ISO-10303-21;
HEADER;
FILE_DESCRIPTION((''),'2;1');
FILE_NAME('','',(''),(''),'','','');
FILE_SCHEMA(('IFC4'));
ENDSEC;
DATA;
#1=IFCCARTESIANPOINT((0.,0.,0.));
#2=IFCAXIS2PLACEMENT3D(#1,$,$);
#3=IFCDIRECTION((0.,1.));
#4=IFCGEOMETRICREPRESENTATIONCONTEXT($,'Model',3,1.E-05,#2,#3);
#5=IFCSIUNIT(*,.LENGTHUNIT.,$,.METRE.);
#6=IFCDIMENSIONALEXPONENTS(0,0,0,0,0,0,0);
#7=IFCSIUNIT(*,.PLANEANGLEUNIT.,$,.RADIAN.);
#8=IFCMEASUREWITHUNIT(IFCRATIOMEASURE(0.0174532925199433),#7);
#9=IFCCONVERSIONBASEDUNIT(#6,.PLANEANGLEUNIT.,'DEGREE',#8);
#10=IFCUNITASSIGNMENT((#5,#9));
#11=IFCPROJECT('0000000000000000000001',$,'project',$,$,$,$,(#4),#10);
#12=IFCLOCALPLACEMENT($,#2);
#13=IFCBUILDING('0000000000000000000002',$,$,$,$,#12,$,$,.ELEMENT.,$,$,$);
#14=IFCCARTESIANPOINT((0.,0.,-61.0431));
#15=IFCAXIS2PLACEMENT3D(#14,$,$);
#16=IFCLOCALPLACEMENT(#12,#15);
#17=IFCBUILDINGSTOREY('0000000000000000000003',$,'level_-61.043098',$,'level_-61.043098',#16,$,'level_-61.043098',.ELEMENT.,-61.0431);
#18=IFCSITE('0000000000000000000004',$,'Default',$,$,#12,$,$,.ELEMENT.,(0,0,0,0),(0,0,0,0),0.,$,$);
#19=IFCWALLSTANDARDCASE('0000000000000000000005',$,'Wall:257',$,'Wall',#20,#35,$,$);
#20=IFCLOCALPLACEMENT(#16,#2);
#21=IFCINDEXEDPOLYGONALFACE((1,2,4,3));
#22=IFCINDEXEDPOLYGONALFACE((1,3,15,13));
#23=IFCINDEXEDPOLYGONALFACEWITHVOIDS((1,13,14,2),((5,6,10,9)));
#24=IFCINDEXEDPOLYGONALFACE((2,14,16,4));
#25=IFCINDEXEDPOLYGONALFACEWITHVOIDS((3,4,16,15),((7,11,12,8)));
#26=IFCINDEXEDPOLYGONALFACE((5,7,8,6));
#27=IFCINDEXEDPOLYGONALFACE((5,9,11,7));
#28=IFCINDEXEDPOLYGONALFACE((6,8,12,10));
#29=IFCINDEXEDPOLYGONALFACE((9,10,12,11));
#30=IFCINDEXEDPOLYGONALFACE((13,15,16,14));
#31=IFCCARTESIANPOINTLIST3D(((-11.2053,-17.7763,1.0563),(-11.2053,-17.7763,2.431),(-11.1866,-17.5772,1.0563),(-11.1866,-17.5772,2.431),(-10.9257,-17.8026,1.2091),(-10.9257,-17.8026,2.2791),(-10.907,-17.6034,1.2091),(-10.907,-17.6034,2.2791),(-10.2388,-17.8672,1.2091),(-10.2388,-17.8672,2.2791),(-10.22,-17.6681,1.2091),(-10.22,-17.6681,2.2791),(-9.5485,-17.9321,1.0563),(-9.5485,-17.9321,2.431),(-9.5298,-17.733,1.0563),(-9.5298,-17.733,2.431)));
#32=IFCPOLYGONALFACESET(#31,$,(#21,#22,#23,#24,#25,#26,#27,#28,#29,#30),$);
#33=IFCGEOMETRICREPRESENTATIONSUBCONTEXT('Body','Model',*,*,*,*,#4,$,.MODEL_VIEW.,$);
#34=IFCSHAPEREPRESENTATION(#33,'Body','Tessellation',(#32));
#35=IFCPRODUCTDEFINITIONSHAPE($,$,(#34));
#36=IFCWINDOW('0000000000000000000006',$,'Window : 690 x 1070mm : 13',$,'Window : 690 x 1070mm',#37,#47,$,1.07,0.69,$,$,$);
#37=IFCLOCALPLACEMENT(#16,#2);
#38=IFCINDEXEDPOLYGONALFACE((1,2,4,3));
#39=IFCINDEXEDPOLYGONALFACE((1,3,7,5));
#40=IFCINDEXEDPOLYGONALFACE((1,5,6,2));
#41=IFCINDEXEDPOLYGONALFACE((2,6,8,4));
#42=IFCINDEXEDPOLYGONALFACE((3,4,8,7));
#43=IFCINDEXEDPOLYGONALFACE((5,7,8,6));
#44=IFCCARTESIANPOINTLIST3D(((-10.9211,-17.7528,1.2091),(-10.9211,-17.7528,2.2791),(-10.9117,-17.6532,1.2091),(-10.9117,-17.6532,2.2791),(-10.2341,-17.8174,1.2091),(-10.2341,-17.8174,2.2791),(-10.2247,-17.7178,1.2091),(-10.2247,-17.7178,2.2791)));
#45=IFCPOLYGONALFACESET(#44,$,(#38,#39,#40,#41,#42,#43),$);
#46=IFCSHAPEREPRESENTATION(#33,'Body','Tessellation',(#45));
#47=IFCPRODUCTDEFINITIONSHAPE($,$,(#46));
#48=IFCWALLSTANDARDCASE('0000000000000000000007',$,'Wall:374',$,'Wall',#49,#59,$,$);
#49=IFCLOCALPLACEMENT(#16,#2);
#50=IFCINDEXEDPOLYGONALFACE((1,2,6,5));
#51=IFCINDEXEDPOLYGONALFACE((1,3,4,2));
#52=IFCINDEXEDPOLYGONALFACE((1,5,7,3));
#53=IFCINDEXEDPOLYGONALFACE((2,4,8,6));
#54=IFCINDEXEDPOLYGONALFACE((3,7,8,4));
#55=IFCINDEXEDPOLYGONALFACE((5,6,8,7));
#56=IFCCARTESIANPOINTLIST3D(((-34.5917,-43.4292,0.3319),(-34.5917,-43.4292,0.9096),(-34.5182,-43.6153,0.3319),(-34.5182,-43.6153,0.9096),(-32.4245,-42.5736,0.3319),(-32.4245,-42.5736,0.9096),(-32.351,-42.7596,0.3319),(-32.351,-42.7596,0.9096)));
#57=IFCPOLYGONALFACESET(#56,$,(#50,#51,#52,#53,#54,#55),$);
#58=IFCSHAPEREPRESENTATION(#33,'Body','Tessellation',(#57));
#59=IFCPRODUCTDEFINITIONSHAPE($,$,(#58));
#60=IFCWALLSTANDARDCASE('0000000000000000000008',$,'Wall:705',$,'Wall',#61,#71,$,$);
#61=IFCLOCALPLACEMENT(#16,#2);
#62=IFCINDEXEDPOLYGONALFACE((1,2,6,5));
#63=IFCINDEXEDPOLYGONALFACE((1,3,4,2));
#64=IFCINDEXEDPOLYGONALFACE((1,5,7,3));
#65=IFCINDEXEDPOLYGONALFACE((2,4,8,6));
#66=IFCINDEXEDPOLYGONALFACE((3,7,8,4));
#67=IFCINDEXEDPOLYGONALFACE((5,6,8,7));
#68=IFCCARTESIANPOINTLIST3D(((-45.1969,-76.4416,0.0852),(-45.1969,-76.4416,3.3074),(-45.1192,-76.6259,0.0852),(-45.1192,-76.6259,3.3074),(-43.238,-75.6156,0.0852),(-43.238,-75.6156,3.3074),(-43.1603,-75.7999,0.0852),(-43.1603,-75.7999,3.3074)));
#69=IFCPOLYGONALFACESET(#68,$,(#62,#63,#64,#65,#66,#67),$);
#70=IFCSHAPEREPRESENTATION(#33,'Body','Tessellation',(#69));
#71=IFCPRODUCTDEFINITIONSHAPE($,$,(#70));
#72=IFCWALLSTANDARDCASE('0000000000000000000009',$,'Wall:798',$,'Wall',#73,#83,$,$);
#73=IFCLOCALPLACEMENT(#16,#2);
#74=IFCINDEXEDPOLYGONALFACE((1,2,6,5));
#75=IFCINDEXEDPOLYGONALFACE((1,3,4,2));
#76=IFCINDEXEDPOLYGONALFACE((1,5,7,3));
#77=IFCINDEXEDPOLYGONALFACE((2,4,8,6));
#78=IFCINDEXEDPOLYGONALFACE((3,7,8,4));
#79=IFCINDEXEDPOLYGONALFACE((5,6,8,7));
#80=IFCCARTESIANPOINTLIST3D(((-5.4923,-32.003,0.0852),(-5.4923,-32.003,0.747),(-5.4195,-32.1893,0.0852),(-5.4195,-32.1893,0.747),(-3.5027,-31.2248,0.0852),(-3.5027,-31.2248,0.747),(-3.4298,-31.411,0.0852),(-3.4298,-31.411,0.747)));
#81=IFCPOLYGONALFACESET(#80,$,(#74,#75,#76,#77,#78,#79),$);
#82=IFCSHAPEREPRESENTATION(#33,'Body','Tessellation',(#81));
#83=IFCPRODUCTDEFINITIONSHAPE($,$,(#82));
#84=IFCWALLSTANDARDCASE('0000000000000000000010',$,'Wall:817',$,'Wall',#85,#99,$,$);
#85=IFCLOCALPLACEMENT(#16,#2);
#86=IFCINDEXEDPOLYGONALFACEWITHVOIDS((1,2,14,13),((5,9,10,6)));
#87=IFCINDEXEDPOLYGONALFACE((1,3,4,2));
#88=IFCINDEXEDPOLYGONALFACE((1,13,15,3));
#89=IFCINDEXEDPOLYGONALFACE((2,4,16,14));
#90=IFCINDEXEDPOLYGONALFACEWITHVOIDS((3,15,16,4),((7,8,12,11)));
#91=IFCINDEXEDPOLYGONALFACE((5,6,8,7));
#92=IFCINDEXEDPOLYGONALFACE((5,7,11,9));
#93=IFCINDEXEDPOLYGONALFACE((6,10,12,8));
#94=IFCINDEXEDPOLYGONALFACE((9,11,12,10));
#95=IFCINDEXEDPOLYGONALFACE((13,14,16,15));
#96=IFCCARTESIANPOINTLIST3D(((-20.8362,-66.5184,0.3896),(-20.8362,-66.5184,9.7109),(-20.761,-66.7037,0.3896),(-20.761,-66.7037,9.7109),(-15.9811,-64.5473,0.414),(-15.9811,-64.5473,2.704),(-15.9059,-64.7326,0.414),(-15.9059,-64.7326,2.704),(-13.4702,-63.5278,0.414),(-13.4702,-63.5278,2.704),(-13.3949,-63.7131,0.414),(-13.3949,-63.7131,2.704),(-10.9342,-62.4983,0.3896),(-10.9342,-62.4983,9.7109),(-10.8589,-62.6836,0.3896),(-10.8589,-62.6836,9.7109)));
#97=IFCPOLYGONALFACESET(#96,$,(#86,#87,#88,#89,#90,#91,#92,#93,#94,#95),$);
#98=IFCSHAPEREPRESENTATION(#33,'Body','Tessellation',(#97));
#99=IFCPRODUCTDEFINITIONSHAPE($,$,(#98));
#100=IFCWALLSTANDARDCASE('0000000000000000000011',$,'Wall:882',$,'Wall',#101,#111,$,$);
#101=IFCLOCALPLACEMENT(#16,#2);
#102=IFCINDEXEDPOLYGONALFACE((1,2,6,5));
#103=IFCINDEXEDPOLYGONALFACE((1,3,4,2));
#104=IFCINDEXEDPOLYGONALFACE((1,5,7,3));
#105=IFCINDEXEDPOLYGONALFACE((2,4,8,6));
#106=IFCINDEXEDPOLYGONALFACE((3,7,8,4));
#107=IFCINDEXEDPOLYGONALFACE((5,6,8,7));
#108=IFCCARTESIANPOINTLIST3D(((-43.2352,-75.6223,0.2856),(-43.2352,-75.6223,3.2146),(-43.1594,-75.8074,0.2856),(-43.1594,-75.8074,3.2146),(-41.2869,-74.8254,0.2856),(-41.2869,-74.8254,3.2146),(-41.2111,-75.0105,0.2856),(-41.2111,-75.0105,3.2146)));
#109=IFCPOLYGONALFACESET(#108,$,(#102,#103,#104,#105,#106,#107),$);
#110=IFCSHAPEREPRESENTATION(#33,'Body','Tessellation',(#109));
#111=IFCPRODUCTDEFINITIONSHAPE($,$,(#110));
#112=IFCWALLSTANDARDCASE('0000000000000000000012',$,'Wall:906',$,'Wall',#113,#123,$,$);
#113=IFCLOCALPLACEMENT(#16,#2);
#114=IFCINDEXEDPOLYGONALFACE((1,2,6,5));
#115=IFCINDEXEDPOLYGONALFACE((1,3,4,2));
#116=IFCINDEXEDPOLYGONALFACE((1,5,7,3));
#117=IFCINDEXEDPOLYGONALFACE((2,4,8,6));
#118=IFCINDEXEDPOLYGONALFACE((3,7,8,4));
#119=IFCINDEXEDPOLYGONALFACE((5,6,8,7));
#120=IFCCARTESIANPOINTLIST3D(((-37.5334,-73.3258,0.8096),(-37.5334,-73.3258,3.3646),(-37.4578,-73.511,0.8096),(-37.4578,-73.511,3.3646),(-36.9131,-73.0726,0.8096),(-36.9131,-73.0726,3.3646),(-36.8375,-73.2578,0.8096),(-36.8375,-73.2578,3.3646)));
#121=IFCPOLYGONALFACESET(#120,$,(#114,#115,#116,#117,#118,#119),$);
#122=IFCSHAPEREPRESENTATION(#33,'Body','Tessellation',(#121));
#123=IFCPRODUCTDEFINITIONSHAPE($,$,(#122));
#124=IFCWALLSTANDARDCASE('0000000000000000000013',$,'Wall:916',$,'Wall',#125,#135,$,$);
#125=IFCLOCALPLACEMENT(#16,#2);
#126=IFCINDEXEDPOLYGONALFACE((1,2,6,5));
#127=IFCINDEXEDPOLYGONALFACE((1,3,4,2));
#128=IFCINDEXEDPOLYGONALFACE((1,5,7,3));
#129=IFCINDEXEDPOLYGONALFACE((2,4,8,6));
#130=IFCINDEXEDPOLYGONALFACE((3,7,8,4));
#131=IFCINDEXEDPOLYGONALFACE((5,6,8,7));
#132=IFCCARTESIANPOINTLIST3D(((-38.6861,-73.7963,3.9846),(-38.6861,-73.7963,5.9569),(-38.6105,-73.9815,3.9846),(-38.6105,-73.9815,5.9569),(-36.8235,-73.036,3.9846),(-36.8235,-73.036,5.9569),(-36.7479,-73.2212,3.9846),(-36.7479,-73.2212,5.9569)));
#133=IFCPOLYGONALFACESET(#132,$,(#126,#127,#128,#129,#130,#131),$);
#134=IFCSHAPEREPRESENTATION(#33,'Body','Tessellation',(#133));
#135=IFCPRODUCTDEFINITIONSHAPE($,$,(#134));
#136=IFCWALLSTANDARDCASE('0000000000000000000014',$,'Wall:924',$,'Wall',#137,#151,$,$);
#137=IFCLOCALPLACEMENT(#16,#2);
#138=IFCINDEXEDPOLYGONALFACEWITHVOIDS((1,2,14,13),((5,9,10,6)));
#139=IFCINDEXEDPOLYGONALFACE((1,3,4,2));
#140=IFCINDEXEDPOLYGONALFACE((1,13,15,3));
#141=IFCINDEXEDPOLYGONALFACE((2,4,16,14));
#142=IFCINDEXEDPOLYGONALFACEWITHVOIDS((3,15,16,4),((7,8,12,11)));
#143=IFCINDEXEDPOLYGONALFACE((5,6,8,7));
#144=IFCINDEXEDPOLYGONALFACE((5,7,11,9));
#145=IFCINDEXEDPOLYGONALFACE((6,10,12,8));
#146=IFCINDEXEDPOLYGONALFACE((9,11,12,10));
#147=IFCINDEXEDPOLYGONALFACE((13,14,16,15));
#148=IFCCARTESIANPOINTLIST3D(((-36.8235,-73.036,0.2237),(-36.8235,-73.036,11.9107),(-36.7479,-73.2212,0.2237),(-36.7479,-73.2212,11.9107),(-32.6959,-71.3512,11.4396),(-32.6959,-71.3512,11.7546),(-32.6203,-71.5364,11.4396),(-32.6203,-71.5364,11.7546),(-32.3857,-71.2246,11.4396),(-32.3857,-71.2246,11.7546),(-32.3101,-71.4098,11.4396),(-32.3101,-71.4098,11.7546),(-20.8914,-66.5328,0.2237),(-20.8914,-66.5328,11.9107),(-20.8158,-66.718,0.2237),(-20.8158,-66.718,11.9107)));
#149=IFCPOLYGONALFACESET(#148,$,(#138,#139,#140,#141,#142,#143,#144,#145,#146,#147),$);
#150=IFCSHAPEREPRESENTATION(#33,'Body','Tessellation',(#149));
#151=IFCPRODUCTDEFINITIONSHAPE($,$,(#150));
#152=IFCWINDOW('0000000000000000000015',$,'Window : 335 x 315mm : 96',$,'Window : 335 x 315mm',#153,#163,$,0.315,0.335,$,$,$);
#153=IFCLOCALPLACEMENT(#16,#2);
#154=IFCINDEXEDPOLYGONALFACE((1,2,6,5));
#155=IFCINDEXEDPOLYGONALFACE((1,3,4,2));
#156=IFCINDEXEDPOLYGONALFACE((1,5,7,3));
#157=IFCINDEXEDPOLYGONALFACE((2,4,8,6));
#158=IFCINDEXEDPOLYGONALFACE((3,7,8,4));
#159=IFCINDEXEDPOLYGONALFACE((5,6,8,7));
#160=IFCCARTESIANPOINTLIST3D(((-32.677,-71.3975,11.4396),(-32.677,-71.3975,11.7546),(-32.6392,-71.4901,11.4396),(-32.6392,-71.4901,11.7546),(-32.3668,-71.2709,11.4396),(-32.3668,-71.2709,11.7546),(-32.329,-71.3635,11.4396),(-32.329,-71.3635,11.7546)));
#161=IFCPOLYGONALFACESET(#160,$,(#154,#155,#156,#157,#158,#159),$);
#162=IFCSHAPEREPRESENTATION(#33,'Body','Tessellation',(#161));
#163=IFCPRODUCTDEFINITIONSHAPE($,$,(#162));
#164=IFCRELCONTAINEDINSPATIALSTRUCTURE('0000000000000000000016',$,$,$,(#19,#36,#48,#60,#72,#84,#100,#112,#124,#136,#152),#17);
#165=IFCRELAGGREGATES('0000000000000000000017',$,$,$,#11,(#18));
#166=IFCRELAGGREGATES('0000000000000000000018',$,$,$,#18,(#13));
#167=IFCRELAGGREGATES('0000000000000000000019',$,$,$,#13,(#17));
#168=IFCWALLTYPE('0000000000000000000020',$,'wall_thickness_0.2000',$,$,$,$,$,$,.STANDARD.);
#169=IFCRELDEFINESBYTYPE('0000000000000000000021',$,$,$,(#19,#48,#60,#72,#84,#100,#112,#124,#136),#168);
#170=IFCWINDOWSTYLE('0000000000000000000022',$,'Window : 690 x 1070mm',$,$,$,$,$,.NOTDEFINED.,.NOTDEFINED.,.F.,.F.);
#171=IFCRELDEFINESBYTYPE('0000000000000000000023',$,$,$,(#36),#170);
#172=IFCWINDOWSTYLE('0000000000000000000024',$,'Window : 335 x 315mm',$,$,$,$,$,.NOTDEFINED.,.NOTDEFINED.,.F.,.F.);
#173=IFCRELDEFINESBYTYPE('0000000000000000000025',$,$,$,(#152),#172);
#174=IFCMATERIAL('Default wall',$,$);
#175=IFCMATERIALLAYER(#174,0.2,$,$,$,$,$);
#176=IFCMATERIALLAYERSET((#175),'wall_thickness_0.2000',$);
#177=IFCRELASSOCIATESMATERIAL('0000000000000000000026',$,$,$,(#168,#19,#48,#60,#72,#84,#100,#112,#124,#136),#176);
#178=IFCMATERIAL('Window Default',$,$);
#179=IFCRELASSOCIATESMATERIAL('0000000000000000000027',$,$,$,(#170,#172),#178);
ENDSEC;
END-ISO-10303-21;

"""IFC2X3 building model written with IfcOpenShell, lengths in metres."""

from ifc_helpers import new_model, entity, si_unit, converted_unit, direction, frame, frame_2d, origin, origin_2d_with_axis, place, context, subcontext, project, spatial, polyline, rectangle, outline, extrude, source, transform, mapped, material, layer, layer_set, layer_usage, type_object, type_shapes, element, fill, save


model = new_model("IFC2X3")

# Units and contexts
model_context = context("Model", 3, precision=1e-05, world=origin(), true_north=direction((0.0, 1.0)))
body_context = subcontext(model_context, "Body", "Model", "MODEL_VIEW")
ifc_project = project(units=[si_unit("LENGTHUNIT", "METRE"), converted_unit("PLANEANGLEUNIT", "DEGREE", entity("IfcRatioMeasure", 0.0174532925199433), si_unit("PLANEANGLEUNIT", "RADIAN"), dimensions=[0, 0, 0, 0, 0, 0, 0])], contexts=[model_context])

# Site, building, storey
placement_1 = place(None, origin())
site = spatial("IfcSite", under=ifc_project, at=placement_1, Name="Default", CompositionType="ELEMENT", RefLatitude=(0, 0, 0, 0), RefLongitude=(0, 0, 0, 0), RefElevation=0.0)
building = spatial("IfcBuilding", under=site, at=placement_1, CompositionType="ELEMENT")
storey_placement = place(placement_1, frame((0.0, 0.0, -61.0431)))
storey = spatial("IfcBuildingStorey", under=building, at=storey_placement, Name="level_-61.043098", ObjectType="level_-61.043098", LongName="level_-61.043098", CompositionType="ELEMENT", Elevation=-61.0431)

# Wall, opening, window
ifc_material_1 = material(Name="Default wall")
ifc_layer = layer(ifc_material_1, 0.2)
ifc_layer_set = layer_set([ifc_layer], Name="wall_thickness_0.2000")
ifc_layer_usage = layer_usage(ifc_layer_set, "AXIS2", "POSITIVE", -0.1)
wall_type = type_object("IfcWallType", Name="wall_thickness_0.2000", PredefinedType="STANDARD", material=ifc_layer_set)
placement_2 = place(placement_1, frame((0.0, 0.0, -59.9868)))
wall_1_placement = place(placement_2, frame((-9.5391, -17.8325, 0.0), z_axis=(0.0, 0.0, 1.0), x_axis=(-0.995607, 0.09363, 0.0)))
wall_1 = element("IfcWallStandardCase", 1, at=wall_1_placement, inside=storey, type_object=wall_type, material=ifc_layer_usage, Name="Wall:257", ObjectType="Wall", context=body_context, shape_type="SweptSolid", body=[
    extrude(outline(polyline([(1.6642, -0.1), (1.6642, 0.1), (0.0, 0.1), (0.0, -0.1), (1.6642, -0.1)])), origin(), (0.0, 0.0, 1.0), 1.3747),
])
opening_1_placement = place(wall_1_placement, frame((0.6933, -0.1, 0.1528)))
opening_1 = element("IfcOpeningElement", 2, at=opening_1_placement, cuts=wall_1, ObjectType="Opening", context=body_context, shape_type="SweptSolid", body=[
    extrude(rectangle(XDim=0.69, YDim=1.07, at=frame_2d((0.535, 0.345), x_axis=(0.0, 1.0))), frame((0.0, 0.0, 0.0), z_axis=(0.0, 1.0, 0.0), x_axis=(0.0, 0.0, 1.0)), (0.0, 0.0, 1.0), 0.2),
])
ifc_material_2 = material(Name="Window Default")
window_style_1 = type_object("IfcWindowStyle", Name="Window : 690 x 1070mm", ConstructionType="NOTDEFINED", OperationType="NOTDEFINED", ParameterTakesPrecedence=False, Sizeable=False, material=ifc_material_2)
shared_shape_1 = source(origin(), body_context, "Body", "SweptSolid", [
    extrude(rectangle(XDim=0.1, YDim=0.69, at=origin_2d_with_axis()), frame((0.345, 0.1, 0.0), z_axis=(0.0, 0.0, 1.0), x_axis=(0.0, 1.0, 0.0)), (0.0, 0.0, 1.0), 1.07),
])
type_shapes(window_style_1, [shared_shape_1])
window_1_placement = place(opening_1_placement, origin())
window_1 = element("IfcWindow", 3, at=window_1_placement, inside=storey, type_object=window_style_1, Name="Window : 690 x 1070mm : 13", ObjectType="Window : 690 x 1070mm", OverallHeight=1.07, OverallWidth=0.69, context=body_context, shape_type="MappedRepresentation", body=[
    mapped(shared_shape_1, transform((0.0, 0.0, 0.0), scale=1.0)),
])
fill(opening_1, window_1)

# Walls
placement_3 = place(placement_1, frame((0.0, 0.0, -60.7112)))
wall_2_placement = place(placement_3, frame((-34.5549, -43.5223, 0.0), z_axis=(0.0, 0.0, 1.0), x_axis=(0.930127, 0.367237, 0.0)))
element("IfcWallStandardCase", 4, at=wall_2_placement, inside=storey, type_object=wall_type, material=ifc_layer_usage, Name="Wall:374", ObjectType="Wall", context=body_context, shape_type="SweptSolid", body=[
    extrude(outline(polyline([(2.33, -0.1), (2.33, 0.1), (0.0, 0.1), (0.0, -0.1), (2.33, -0.1)])), origin(), (0.0, 0.0, 1.0), 0.5777),
])
placement_4 = place(placement_1, frame((0.0, 0.0, -60.9579)))
wall_3_placement = place(placement_4, frame((-43.1991, -75.7078, 0.0), z_axis=(0.0, 0.0, 1.0), x_axis=(-0.921446, -0.388506, 0.0)))
element("IfcWallStandardCase", 5, at=wall_3_placement, inside=storey, type_object=wall_type, material=ifc_layer_usage, Name="Wall:705", ObjectType="Wall", context=body_context, shape_type="SweptSolid", body=[
    extrude(outline(polyline([(2.126, -0.1), (2.126, 0.1), (0.0, 0.1), (0.0, -0.1), (2.126, -0.1)])), origin(), (0.0, 0.0, 1.0), 3.2222),
])
placement_5 = place(placement_1, frame((0.0, 0.0, -60.9579)))
wall_4_placement = place(placement_5, frame((-5.4559, -32.0962, 0.0), z_axis=(0.0, 0.0, 1.0), x_axis=(0.931289, 0.364282, 0.0)))
element("IfcWallStandardCase", 6, at=wall_4_placement, inside=storey, type_object=wall_type, material=ifc_layer_usage, Name="Wall:798", ObjectType="Wall", context=body_context, shape_type="SweptSolid", body=[
    extrude(outline(polyline([(2.1364, -0.1), (2.1364, 0.1), (0.0, 0.1), (0.0, -0.1), (2.1364, -0.1)])), origin(), (0.0, 0.0, 1.0), 0.6618),
])

# Wall, opening
placement_6 = place(placement_1, frame((0.0, 0.0, -60.6535)))
wall_5_placement = place(placement_6, frame((-10.8965, -62.5909, 0.0), z_axis=(0.0, 0.0, 1.0), x_axis=(-0.926551, -0.37617, 0.0)))
wall_5 = element("IfcWallStandardCase", 7, at=wall_5_placement, inside=storey, type_object=wall_type, material=ifc_layer_usage, Name="Wall:817", ObjectType="Wall", context=body_context, shape_type="SweptSolid", body=[
    extrude(outline(polyline([(10.687, -0.1), (10.687, 0.1), (0.0, 0.1), (0.0, -0.1), (10.687, -0.1)])), origin(), (0.0, 0.0, 1.0), 9.3214),
])
opening_2_placement = place(wall_5_placement, frame((2.737, -0.1, 0.0244)))
element("IfcOpeningElement", 8, at=opening_2_placement, cuts=wall_5, ObjectType="Opening", context=body_context, shape_type="SweptSolid", body=[
    extrude(rectangle(XDim=2.71, YDim=2.29, at=frame_2d((1.145, 1.355), x_axis=(0.0, 1.0))), frame((0.0, 0.0, 0.0), z_axis=(0.0, 1.0, 0.0), x_axis=(0.0, 0.0, 1.0)), (0.0, 0.0, 1.0), 0.2),
])

# Walls
placement_7 = place(placement_1, frame((0.0, 0.0, -60.7575)))
wall_6_placement = place(placement_7, frame((-43.1973, -75.7149, 0.0), z_axis=(0.0, 0.0, 1.0), x_axis=(0.925558, 0.378606, 0.0)))
element("IfcWallStandardCase", 9, at=wall_6_placement, inside=storey, type_object=wall_type, material=ifc_layer_usage, Name="Wall:882", ObjectType="Wall", context=body_context, shape_type="SweptSolid", body=[
    extrude(outline(polyline([(2.105, -0.1), (2.105, 0.1), (0.0, 0.1), (0.0, -0.1), (2.105, -0.1)])), origin(), (0.0, 0.0, 1.0), 2.929),
])
placement_8 = place(placement_1, frame((0.0, 0.0, -60.2335)))
wall_7_placement = place(placement_8, frame((-37.4956, -73.4184, 0.0), z_axis=(0.0, 0.0, 1.0), x_axis=(0.925839, 0.377917, 0.0)))
element("IfcWallStandardCase", 10, at=wall_7_placement, inside=storey, type_object=wall_type, material=ifc_layer_usage, Name="Wall:906", ObjectType="Wall", context=body_context, shape_type="SweptSolid", body=[
    extrude(outline(polyline([(0.67, -0.1), (0.67, 0.1), (0.0, 0.1), (0.0, -0.1), (0.67, -0.1)])), origin(), (0.0, 0.0, 1.0), 2.555),
])
placement_9 = place(placement_1, frame((0.0, 0.0, -57.0585)))
wall_8_placement = place(placement_9, frame((-38.6483, -73.8889, 0.0), z_axis=(0.0, 0.0, 1.0), x_axis=(0.925841, 0.377914, 0.0)))
element("IfcWallStandardCase", 11, at=wall_8_placement, inside=storey, type_object=wall_type, material=ifc_layer_usage, Name="Wall:916", ObjectType="Wall", context=body_context, shape_type="SweptSolid", body=[
    extrude(outline(polyline([(2.0118, -0.1), (2.0118, 0.1), (0.0, 0.1), (0.0, -0.1), (2.0118, -0.1)])), origin(), (0.0, 0.0, 1.0), 1.9724),
])

# Wall, opening, window
placement_10 = place(placement_1, frame((0.0, 0.0, -60.8194)))
wall_9_placement = place(placement_10, frame((-36.7857, -73.1286, 0.0), z_axis=(0.0, 0.0, 1.0), x_axis=(0.925841, 0.377914, 0.0)))
wall_9 = element("IfcWallStandardCase", 12, at=wall_9_placement, inside=storey, type_object=wall_type, material=ifc_layer_usage, Name="Wall:924", ObjectType="Wall", context=body_context, shape_type="SweptSolid", body=[
    extrude(outline(polyline([(17.2082, -0.1), (17.2082, 0.1), (0.0, 0.1), (0.0, -0.1), (17.2082, -0.1)])), origin(), (0.0, 0.0, 1.0), 11.687),
])
opening_3_placement = place(wall_9_placement, frame((4.4582, -0.1, 11.2159)))
opening_3 = element("IfcOpeningElement", 13, at=opening_3_placement, cuts=wall_9, ObjectType="Opening", context=body_context, shape_type="SweptSolid", body=[
    extrude(rectangle(XDim=0.335, YDim=0.315, at=frame_2d((0.1575, 0.1675), x_axis=(0.0, 1.0))), frame((0.0, 0.0, 0.0), z_axis=(0.0, 1.0, 0.0), x_axis=(0.0, 0.0, 1.0)), (0.0, 0.0, 1.0), 0.2),
])
window_style_2 = type_object("IfcWindowStyle", Name="Window : 335 x 315mm", ConstructionType="NOTDEFINED", OperationType="NOTDEFINED", ParameterTakesPrecedence=False, Sizeable=False, material=ifc_material_2)
shared_shape_2 = source(origin(), body_context, "Body", "SweptSolid", [
    extrude(rectangle(XDim=0.1, YDim=0.335, at=origin_2d_with_axis()), frame((0.1675, 0.1, 0.0), z_axis=(0.0, 0.0, 1.0), x_axis=(0.0, 1.0, 0.0)), (0.0, 0.0, 1.0), 0.315),
])
type_shapes(window_style_2, [shared_shape_2])
window_2_placement = place(opening_3_placement, origin())
window_2 = element("IfcWindow", 14, at=window_2_placement, inside=storey, type_object=window_style_2, Name="Window : 335 x 315mm : 96", ObjectType="Window : 335 x 315mm", OverallHeight=0.315, OverallWidth=0.335, context=body_context, shape_type="MappedRepresentation", body=[
    mapped(shared_shape_2, transform((0.0, 0.0, 0.0), scale=1.0)),
])
fill(opening_3, window_2)

save(model, "model.ifc")
